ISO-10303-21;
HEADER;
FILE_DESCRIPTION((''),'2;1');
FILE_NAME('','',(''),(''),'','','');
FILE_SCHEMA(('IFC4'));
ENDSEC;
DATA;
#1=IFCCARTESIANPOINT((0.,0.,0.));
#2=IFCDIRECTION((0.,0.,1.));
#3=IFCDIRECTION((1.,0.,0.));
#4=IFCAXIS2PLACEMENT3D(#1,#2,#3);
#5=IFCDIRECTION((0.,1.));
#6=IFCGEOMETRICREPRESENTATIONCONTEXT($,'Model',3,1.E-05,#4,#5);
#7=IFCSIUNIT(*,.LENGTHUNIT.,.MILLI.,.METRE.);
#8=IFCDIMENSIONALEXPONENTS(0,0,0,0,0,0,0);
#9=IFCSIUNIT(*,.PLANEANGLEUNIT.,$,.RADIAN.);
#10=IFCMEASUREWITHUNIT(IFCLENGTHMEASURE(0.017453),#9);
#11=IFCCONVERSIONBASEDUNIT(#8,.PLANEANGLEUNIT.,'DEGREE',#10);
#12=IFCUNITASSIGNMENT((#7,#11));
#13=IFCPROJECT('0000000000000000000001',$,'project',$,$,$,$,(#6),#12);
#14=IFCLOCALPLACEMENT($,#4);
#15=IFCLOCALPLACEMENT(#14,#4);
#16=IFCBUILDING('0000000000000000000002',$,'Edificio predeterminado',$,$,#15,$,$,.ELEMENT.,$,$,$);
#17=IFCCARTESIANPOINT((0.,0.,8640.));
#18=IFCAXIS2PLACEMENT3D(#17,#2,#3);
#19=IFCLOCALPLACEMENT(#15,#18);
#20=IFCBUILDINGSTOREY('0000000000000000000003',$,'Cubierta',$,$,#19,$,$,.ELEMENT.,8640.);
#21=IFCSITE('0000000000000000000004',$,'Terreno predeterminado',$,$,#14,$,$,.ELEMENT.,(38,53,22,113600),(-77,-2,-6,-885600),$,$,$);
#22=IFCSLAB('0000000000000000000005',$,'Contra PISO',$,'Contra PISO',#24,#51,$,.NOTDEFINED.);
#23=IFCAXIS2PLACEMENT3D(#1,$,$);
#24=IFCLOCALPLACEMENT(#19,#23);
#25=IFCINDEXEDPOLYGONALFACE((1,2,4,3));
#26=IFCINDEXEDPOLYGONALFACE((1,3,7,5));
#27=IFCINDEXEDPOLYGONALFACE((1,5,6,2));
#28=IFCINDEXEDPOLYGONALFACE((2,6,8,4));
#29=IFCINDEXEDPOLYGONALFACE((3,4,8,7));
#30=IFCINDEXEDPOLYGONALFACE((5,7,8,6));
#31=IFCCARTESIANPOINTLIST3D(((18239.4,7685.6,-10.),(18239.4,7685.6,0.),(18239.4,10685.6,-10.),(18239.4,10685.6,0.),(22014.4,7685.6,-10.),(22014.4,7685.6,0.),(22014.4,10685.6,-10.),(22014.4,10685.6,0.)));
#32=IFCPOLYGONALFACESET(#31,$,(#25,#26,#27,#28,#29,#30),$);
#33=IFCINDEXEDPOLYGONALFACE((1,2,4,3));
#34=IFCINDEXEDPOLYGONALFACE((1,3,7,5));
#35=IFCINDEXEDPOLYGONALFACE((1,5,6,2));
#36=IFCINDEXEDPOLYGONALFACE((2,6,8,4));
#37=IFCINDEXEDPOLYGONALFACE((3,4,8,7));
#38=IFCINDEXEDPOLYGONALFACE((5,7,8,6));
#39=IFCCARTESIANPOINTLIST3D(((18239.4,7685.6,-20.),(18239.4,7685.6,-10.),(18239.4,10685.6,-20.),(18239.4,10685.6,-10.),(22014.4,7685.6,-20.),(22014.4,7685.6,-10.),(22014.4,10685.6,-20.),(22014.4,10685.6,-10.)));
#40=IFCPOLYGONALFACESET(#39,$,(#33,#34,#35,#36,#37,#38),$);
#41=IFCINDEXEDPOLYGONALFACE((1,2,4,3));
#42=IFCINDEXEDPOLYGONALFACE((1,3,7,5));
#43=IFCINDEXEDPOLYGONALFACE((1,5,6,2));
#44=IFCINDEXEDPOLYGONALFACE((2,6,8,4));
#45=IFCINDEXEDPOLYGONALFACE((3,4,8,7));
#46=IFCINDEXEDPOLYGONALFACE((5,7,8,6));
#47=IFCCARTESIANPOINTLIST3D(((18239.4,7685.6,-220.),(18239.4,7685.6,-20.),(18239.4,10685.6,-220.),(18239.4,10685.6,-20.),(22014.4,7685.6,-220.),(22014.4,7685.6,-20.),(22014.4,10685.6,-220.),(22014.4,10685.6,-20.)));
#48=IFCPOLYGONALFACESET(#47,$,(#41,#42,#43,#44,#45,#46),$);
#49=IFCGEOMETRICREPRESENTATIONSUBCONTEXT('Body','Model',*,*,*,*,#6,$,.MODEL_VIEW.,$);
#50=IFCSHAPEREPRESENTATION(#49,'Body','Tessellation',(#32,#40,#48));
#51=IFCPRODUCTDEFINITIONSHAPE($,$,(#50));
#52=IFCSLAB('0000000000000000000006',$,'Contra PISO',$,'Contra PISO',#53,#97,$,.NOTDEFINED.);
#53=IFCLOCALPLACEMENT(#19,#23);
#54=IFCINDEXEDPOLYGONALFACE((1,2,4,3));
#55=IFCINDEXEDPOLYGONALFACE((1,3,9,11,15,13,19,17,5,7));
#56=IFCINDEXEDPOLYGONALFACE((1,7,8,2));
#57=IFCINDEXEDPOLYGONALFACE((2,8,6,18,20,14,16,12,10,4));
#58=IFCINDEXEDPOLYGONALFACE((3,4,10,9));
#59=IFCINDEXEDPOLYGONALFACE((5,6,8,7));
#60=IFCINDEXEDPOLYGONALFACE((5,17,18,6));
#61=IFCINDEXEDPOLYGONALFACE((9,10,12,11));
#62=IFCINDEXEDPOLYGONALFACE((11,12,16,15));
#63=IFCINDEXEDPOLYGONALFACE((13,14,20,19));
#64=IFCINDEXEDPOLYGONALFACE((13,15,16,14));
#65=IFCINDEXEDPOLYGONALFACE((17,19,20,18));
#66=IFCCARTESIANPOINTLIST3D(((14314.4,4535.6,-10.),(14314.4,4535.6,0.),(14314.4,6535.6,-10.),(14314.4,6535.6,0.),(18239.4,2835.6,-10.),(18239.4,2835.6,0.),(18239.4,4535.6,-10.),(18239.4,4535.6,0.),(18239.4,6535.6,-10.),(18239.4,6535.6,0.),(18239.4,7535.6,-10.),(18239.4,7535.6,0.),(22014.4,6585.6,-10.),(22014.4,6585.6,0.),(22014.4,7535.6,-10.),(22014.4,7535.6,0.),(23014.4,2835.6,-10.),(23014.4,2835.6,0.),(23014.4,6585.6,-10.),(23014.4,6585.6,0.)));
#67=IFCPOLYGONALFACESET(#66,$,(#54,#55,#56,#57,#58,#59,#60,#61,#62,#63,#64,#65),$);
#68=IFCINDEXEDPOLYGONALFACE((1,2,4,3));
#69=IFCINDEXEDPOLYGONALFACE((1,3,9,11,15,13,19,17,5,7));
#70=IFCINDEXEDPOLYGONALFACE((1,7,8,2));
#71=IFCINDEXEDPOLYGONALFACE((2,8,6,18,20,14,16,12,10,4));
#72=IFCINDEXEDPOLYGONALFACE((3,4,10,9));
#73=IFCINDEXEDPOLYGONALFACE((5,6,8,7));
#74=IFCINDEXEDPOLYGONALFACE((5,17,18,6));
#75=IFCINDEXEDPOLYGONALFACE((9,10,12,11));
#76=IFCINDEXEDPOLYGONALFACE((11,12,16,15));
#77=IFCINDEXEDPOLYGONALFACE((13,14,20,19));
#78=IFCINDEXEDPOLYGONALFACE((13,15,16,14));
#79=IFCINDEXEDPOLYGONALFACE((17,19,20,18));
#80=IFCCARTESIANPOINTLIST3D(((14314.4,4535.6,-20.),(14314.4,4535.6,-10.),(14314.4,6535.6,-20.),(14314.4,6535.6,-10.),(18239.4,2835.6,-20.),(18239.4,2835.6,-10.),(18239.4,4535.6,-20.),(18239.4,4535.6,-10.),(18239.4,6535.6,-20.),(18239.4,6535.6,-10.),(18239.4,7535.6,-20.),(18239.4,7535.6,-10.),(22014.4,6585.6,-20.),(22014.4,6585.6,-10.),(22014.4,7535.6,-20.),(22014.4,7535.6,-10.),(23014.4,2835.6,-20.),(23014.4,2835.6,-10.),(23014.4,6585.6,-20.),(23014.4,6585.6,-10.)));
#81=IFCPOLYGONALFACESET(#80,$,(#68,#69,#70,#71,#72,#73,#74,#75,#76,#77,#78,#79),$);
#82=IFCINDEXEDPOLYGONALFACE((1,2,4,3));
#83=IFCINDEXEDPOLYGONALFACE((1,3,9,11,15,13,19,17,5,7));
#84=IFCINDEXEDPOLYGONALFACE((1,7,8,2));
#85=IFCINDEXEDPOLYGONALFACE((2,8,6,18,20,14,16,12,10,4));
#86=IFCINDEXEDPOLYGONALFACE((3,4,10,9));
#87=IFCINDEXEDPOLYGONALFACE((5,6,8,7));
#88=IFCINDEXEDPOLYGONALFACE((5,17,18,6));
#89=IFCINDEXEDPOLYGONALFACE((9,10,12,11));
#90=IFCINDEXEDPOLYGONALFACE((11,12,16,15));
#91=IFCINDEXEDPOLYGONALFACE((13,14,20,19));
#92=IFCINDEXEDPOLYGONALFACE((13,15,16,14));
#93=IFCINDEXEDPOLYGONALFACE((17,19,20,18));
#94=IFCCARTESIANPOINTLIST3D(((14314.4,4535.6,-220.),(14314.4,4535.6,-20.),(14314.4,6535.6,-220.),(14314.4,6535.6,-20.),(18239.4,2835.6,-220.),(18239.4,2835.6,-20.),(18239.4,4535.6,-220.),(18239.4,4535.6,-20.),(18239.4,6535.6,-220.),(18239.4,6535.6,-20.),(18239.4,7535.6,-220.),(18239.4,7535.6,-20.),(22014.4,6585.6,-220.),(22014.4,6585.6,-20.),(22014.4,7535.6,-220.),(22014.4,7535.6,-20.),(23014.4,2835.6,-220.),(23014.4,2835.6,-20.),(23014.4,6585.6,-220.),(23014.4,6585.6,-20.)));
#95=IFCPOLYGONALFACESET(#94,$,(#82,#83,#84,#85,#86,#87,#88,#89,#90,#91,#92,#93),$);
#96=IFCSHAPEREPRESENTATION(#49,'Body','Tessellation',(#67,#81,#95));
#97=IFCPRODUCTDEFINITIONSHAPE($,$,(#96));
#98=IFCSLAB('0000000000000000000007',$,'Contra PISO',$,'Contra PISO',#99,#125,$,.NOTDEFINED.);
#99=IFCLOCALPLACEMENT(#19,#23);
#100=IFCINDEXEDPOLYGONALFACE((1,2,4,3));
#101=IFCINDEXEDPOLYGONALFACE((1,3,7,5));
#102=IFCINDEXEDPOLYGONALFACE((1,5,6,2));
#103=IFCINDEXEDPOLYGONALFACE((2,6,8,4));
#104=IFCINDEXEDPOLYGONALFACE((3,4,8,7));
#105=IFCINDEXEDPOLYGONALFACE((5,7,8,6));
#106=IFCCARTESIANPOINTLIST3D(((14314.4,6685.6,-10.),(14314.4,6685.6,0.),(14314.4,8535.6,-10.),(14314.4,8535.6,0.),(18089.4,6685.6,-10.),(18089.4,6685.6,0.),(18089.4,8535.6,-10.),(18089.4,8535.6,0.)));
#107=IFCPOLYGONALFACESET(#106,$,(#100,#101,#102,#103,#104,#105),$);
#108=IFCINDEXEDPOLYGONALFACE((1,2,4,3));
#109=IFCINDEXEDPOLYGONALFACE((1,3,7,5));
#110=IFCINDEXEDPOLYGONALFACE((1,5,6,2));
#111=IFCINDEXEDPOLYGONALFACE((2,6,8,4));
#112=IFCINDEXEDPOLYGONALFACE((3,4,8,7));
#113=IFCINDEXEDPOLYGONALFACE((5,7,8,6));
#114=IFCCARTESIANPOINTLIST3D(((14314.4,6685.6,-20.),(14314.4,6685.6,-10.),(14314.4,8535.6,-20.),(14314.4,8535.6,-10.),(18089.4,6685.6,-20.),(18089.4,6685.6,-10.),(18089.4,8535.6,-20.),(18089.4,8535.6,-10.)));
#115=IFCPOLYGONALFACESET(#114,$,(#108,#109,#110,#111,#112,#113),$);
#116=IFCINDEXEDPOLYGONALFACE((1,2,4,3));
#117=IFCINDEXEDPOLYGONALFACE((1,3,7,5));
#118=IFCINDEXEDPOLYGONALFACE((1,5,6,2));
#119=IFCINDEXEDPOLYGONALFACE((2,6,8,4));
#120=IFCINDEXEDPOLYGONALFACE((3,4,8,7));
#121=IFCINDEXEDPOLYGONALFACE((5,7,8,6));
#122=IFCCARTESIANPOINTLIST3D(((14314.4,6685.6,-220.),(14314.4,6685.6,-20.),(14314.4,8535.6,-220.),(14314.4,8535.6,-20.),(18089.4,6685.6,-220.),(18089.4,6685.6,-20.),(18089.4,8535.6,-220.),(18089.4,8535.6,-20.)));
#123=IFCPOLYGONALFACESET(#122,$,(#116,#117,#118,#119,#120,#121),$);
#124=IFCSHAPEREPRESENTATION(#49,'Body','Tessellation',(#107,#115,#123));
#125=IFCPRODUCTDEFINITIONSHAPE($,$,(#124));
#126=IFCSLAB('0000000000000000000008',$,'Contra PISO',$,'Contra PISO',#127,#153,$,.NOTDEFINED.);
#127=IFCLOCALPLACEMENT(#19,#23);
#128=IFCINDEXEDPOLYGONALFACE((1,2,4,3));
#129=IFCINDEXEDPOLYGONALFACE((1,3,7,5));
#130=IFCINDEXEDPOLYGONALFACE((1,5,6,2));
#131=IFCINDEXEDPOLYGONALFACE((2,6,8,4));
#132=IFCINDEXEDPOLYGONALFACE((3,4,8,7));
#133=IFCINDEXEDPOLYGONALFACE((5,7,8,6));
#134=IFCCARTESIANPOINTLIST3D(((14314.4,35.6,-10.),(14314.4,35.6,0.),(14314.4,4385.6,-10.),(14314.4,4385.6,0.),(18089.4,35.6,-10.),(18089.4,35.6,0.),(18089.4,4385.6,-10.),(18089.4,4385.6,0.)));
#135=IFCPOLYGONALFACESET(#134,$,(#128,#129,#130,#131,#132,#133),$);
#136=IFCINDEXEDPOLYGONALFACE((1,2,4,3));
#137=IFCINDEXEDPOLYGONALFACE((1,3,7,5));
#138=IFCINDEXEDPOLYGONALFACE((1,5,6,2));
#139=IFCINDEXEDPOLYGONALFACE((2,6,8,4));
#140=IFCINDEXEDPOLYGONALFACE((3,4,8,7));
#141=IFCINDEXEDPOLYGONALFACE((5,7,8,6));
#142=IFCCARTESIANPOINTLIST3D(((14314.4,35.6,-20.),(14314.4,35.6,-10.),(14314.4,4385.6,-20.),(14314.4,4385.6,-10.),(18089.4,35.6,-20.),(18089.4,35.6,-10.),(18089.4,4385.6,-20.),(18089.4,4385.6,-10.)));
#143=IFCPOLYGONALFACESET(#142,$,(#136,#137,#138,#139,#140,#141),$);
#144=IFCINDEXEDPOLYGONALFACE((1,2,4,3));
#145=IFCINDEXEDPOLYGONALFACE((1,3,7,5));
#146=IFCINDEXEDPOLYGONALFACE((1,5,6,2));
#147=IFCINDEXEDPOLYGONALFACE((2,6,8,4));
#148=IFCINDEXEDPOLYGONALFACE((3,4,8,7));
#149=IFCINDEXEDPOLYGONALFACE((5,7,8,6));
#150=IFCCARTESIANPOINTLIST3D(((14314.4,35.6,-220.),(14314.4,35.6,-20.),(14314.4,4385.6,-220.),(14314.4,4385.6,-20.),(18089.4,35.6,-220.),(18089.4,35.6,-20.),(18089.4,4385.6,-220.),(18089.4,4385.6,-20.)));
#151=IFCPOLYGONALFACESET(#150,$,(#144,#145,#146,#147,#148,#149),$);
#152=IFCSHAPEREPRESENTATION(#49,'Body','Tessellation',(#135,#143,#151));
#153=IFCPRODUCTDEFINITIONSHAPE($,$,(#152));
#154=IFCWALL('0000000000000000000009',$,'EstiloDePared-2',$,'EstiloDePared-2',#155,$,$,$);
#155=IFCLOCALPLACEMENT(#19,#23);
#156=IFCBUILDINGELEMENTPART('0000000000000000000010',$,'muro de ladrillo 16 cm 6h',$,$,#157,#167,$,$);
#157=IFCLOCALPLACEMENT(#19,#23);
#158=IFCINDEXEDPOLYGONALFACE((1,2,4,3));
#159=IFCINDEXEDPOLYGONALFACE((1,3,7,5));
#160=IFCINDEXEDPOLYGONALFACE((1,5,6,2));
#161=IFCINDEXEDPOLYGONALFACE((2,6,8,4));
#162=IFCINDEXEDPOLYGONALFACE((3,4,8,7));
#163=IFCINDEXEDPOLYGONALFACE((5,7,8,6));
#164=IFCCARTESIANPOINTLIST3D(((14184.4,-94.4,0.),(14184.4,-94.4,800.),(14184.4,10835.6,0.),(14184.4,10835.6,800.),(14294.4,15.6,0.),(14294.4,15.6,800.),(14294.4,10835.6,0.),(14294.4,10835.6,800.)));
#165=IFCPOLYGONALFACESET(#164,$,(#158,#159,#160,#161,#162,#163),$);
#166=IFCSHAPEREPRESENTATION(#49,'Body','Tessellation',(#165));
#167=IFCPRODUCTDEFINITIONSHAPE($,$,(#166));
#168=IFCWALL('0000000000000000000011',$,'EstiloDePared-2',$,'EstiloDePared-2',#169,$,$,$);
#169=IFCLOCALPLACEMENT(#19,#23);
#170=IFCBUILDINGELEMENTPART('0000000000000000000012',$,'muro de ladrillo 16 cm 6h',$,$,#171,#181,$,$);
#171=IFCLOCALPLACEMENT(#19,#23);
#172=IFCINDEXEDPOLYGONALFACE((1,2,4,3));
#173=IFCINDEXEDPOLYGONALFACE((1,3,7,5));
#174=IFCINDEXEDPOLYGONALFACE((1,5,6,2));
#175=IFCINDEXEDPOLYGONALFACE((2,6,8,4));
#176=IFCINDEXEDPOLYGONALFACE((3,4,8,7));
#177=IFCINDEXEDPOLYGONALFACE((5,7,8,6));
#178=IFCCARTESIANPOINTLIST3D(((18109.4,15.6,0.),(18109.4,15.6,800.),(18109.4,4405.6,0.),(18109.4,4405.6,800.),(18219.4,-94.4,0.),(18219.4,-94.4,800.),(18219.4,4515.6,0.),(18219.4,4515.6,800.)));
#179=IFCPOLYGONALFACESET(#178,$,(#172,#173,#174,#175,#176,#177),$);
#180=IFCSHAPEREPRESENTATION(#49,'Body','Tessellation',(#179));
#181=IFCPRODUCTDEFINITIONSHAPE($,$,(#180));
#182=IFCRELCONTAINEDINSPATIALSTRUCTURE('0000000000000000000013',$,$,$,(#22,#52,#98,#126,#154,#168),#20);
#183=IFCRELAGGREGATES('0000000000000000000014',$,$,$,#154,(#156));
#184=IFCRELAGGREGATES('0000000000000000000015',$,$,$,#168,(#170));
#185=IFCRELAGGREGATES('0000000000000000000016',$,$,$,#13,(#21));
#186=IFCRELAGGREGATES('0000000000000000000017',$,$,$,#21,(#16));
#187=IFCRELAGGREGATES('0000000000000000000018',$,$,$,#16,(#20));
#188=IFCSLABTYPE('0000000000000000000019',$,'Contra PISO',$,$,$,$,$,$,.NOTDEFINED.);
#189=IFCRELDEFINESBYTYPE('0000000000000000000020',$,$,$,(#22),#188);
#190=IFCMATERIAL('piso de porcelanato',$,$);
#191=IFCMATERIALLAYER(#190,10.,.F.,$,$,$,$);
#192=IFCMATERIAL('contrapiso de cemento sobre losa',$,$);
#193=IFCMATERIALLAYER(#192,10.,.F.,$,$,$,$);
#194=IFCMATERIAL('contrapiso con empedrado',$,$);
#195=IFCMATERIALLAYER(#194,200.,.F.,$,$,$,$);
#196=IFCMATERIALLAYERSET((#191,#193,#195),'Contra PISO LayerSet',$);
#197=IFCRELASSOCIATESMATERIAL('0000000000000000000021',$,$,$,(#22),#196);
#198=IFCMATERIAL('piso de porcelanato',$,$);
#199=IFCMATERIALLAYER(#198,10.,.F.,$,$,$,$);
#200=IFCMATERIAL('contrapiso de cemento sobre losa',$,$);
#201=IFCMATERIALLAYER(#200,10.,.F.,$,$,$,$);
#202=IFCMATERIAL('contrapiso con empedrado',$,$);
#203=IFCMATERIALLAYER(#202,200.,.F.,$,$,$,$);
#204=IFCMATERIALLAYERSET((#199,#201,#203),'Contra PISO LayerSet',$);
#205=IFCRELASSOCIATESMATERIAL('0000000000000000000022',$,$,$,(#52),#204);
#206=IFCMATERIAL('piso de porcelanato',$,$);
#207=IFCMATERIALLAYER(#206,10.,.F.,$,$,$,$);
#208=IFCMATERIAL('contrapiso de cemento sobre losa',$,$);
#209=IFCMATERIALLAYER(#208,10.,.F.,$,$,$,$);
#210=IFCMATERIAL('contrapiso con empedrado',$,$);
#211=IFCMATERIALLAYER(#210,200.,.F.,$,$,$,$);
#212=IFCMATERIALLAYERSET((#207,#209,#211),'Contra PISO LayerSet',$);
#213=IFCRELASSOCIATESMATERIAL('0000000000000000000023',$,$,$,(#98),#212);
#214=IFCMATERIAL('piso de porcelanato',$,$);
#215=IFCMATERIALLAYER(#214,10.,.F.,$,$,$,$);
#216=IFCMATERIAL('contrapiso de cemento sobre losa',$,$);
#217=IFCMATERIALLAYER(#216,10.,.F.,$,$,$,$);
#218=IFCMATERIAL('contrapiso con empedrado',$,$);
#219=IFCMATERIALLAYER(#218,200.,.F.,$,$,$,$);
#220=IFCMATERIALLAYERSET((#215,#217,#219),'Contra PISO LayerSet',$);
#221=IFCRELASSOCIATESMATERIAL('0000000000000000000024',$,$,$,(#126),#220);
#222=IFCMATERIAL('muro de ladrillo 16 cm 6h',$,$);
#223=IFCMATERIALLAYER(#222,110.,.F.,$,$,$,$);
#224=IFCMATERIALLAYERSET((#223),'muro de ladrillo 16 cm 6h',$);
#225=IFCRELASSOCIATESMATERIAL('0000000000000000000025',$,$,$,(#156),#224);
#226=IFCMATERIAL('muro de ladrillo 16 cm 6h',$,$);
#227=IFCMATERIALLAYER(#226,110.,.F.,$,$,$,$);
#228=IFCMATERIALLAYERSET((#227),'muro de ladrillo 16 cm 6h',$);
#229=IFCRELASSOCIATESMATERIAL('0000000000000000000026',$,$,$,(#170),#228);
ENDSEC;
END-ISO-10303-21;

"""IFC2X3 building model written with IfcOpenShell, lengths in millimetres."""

from ifc_helpers import new_model, entity, si_unit, converted_unit, direction, frame, origin_with_axes, place, context, subcontext, project, spatial, polyline, outline, extrude, material, layer, layer_set, layer_usage, type_object, element, aggregate, save


model = new_model("IFC2X3")

# Units and contexts
model_context = context("Model", 3, precision=1e-05, world=origin_with_axes(), true_north=direction((0.0, 1.0)))
body_context = subcontext(model_context, "Body", "Model", "MODEL_VIEW")
ifc_project = project(units=[si_unit("LENGTHUNIT", "METRE", prefix="MILLI"), converted_unit("PLANEANGLEUNIT", "DEGREE", entity("IfcLengthMeasure", 0.017453), si_unit("PLANEANGLEUNIT", "RADIAN"), dimensions=[0, 0, 0, 0, 0, 0, 0])], contexts=[model_context])

# Site, building, storey
site_placement = place(None, origin_with_axes())
site = spatial("IfcSite", under=ifc_project, at=site_placement, Name="Terreno predeterminado", CompositionType="ELEMENT", RefLatitude=(38, 53, 22, 113600), RefLongitude=(-77, -2, -6, -885600))
building_placement = place(site_placement, origin_with_axes())
building = spatial("IfcBuilding", under=site, at=building_placement, Name="Edificio predeterminado", CompositionType="ELEMENT")
storey_placement = place(building_placement, frame((0.0, 0.0, 8640.0), z_axis=(0.0, 0.0, 1.0), x_axis=(1.0, 0.0, 0.0)))
storey = spatial("IfcBuildingStorey", under=building, at=storey_placement, Name="Cubierta", CompositionType="ELEMENT", Elevation=8640.0)

# Slabs
ifc_material_1 = material(Name="piso de porcelanato")
ifc_layer_1 = layer(ifc_material_1, 10.0, ventilated=False)
ifc_material_2 = material(Name="contrapiso de cemento sobre losa")
ifc_layer_2 = layer(ifc_material_2, 10.0, ventilated=False)
ifc_material_3 = material(Name="contrapiso con empedrado")
ifc_layer_3 = layer(ifc_material_3, 200.0, ventilated=False)
ifc_layer_set_1 = layer_set([ifc_layer_1, ifc_layer_2, ifc_layer_3], Name="Contra PISO LayerSet")
ifc_layer_usage_1 = layer_usage(ifc_layer_set_1, "AXIS3", "NEGATIVE", 0.0)
slab_type = type_object("IfcSlabType", Name="Contra PISO", PredefinedType="NOTDEFINED")
slab_1_placement = place(storey_placement, frame((0.0, 0.0, -8640.0), z_axis=(0.0, 0.0, 1.0), x_axis=(1.0, 0.0, 0.0)))
element("IfcSlab", 1, at=slab_1_placement, inside=storey, type_object=slab_type, material=ifc_layer_usage_1, Name="Contra PISO", ObjectType="Contra PISO", PredefinedType="NOTDEFINED", context=body_context, shape_type="SweptSolid", body=[
    extrude(outline(polyline([(0.0, 3000.0), (3775.0, 3000.0), (3775.0, 0.0), (0.0, 0.0), (0.0, 3000.0)])), frame((22014.4, 7685.6, 8630.0), z_axis=(0.0, 0.0, -1.0), x_axis=(-1.0, 0.0, 0.0)), (0.0, 0.0, -1.0), 10.0),
    extrude(outline(polyline([(0.0, 3000.0), (3775.0, 3000.0), (3775.0, 0.0), (0.0, 0.0), (0.0, 3000.0)])), frame((22014.4, 7685.6, 8620.0), z_axis=(0.0, 0.0, -1.0), x_axis=(-1.0, 0.0, 0.0)), (0.0, 0.0, -1.0), 10.0),
    extrude(outline(polyline([(0.0, 3000.0), (3775.0, 3000.0), (3775.0, 0.0), (0.0, 0.0), (0.0, 3000.0)])), frame((22014.4, 7685.6, 8420.0), z_axis=(0.0, 0.0, -1.0), x_axis=(-1.0, 0.0, 0.0)), (0.0, 0.0, -1.0), 200.0),
])
ifc_material_4 = material(Name="piso de porcelanato")
ifc_layer_4 = layer(ifc_material_4, 10.0, ventilated=False)
ifc_material_5 = material(Name="contrapiso de cemento sobre losa")
ifc_layer_5 = layer(ifc_material_5, 10.0, ventilated=False)
ifc_material_6 = material(Name="contrapiso con empedrado")
ifc_layer_6 = layer(ifc_material_6, 200.0, ventilated=False)
ifc_layer_set_2 = layer_set([ifc_layer_4, ifc_layer_5, ifc_layer_6], Name="Contra PISO LayerSet")
ifc_layer_usage_2 = layer_usage(ifc_layer_set_2, "AXIS3", "NEGATIVE", 0.0)
slab_2_placement = place(storey_placement, frame((0.0, 0.0, -8640.0), z_axis=(0.0, 0.0, 1.0), x_axis=(1.0, 0.0, 0.0)))
element("IfcSlab", 2, at=slab_2_placement, inside=storey, material=ifc_layer_usage_2, Name="Contra PISO", ObjectType="Contra PISO", PredefinedType="NOTDEFINED", context=body_context, shape_type="SweptSolid", body=[
    extrude(outline(polyline([(0.0, 1000.0), (-3925.0, 1000.0), (-3925.0, 3000.0), (0.0, 3000.0), (0.0, 4700.0), (4775.0, 4700.0), (4775.0, 950.0), (3775.0, 950.0), (3775.0, 0.0), (0.0, 0.0), (0.0, 1000.0)])), frame((18239.4, 7535.6, 8630.0), z_axis=(0.0, 0.0, -1.0), x_axis=(1.0, 0.0, 0.0)), (0.0, 0.0, -1.0), 10.0),
    extrude(outline(polyline([(0.0, 1000.0), (-3925.0, 1000.0), (-3925.0, 3000.0), (0.0, 3000.0), (0.0, 4700.0), (4775.0, 4700.0), (4775.0, 950.0), (3775.0, 950.0), (3775.0, 0.0), (0.0, 0.0), (0.0, 1000.0)])), frame((18239.4, 7535.6, 8620.0), z_axis=(0.0, 0.0, -1.0), x_axis=(1.0, 0.0, 0.0)), (0.0, 0.0, -1.0), 10.0),
    extrude(outline(polyline([(0.0, 1000.0), (-3925.0, 1000.0), (-3925.0, 3000.0), (0.0, 3000.0), (0.0, 4700.0), (4775.0, 4700.0), (4775.0, 950.0), (3775.0, 950.0), (3775.0, 0.0), (0.0, 0.0), (0.0, 1000.0)])), frame((18239.4, 7535.6, 8420.0), z_axis=(0.0, 0.0, -1.0), x_axis=(1.0, 0.0, 0.0)), (0.0, 0.0, -1.0), 200.0),
])
ifc_material_7 = material(Name="piso de porcelanato")
ifc_layer_7 = layer(ifc_material_7, 10.0, ventilated=False)
ifc_material_8 = material(Name="contrapiso de cemento sobre losa")
ifc_layer_8 = layer(ifc_material_8, 10.0, ventilated=False)
ifc_material_9 = material(Name="contrapiso con empedrado")
ifc_layer_9 = layer(ifc_material_9, 200.0, ventilated=False)
ifc_layer_set_3 = layer_set([ifc_layer_7, ifc_layer_8, ifc_layer_9], Name="Contra PISO LayerSet")
ifc_layer_usage_3 = layer_usage(ifc_layer_set_3, "AXIS3", "NEGATIVE", 0.0)
slab_3_placement = place(storey_placement, frame((0.0, 0.0, -8640.0), z_axis=(0.0, 0.0, 1.0), x_axis=(1.0, 0.0, 0.0)))
element("IfcSlab", 3, at=slab_3_placement, inside=storey, material=ifc_layer_usage_3, Name="Contra PISO", ObjectType="Contra PISO", PredefinedType="NOTDEFINED", context=body_context, shape_type="SweptSolid", body=[
    extrude(outline(polyline([(0.0, 1850.0), (3775.0, 1850.0), (3775.0, 0.0), (0.0, 0.0), (0.0, 1850.0)])), frame((18089.4, 6685.6, 8630.0), z_axis=(0.0, 0.0, -1.0), x_axis=(-1.0, 0.0, 0.0)), (0.0, 0.0, -1.0), 10.0),
    extrude(outline(polyline([(0.0, 1850.0), (3775.0, 1850.0), (3775.0, 0.0), (0.0, 0.0), (0.0, 1850.0)])), frame((18089.4, 6685.6, 8620.0), z_axis=(0.0, 0.0, -1.0), x_axis=(-1.0, 0.0, 0.0)), (0.0, 0.0, -1.0), 10.0),
    extrude(outline(polyline([(0.0, 1850.0), (3775.0, 1850.0), (3775.0, 0.0), (0.0, 0.0), (0.0, 1850.0)])), frame((18089.4, 6685.6, 8420.0), z_axis=(0.0, 0.0, -1.0), x_axis=(-1.0, 0.0, 0.0)), (0.0, 0.0, -1.0), 200.0),
])
ifc_material_10 = material(Name="piso de porcelanato")
ifc_layer_10 = layer(ifc_material_10, 10.0, ventilated=False)
ifc_material_11 = material(Name="contrapiso de cemento sobre losa")
ifc_layer_11 = layer(ifc_material_11, 10.0, ventilated=False)
ifc_material_12 = material(Name="contrapiso con empedrado")
ifc_layer_12 = layer(ifc_material_12, 200.0, ventilated=False)
ifc_layer_set_4 = layer_set([ifc_layer_10, ifc_layer_11, ifc_layer_12], Name="Contra PISO LayerSet")
ifc_layer_usage_4 = layer_usage(ifc_layer_set_4, "AXIS3", "NEGATIVE", 0.0)
slab_4_placement = place(storey_placement, frame((0.0, 0.0, -8640.0), z_axis=(0.0, 0.0, 1.0), x_axis=(1.0, 0.0, 0.0)))
element("IfcSlab", 4, at=slab_4_placement, inside=storey, material=ifc_layer_usage_4, Name="Contra PISO", ObjectType="Contra PISO", PredefinedType="NOTDEFINED", context=body_context, shape_type="SweptSolid", body=[
    extrude(outline(polyline([(0.0, 4350.0), (3775.0, 4350.0), (3775.0, 0.0), (0.0, 0.0), (0.0, 4350.0)])), frame((18089.4, 35.6, 8630.0), z_axis=(0.0, 0.0, -1.0), x_axis=(-1.0, 0.0, 0.0)), (0.0, 0.0, -1.0), 10.0),
    extrude(outline(polyline([(0.0, 4350.0), (3775.0, 4350.0), (3775.0, 0.0), (0.0, 0.0), (0.0, 4350.0)])), frame((18089.4, 35.6, 8620.0), z_axis=(0.0, 0.0, -1.0), x_axis=(-1.0, 0.0, 0.0)), (0.0, 0.0, -1.0), 10.0),
    extrude(outline(polyline([(0.0, 4350.0), (3775.0, 4350.0), (3775.0, 0.0), (0.0, 0.0), (0.0, 4350.0)])), frame((18089.4, 35.6, 8420.0), z_axis=(0.0, 0.0, -1.0), x_axis=(-1.0, 0.0, 0.0)), (0.0, 0.0, -1.0), 200.0),
])

# Walls, building element parts
wall_1_placement = place(storey_placement, frame((14239.4, -39.4, 0.0), z_axis=(0.0, 0.0, 1.0), x_axis=(0.0, 1.0, 0.0)))
wall_1 = element("IfcWall", 5, at=wall_1_placement, inside=storey, Name="EstiloDePared-2", ObjectType="EstiloDePared-2")
ifc_material_13 = material(Name="muro de ladrillo 16 cm 6h")
ifc_layer_13 = layer(ifc_material_13, 110.0, ventilated=False)
ifc_layer_set_5 = layer_set([ifc_layer_13], Name="muro de ladrillo 16 cm 6h")
ifc_layer_usage_5 = layer_usage(ifc_layer_set_5, "AXIS2", "NEGATIVE", -55.0)
building_element_part_1_placement = place(wall_1_placement, origin_with_axes())
building_element_part_1 = element("IfcBuildingElementPart", 6, at=building_element_part_1_placement, material=ifc_layer_usage_5, Name="muro de ladrillo 16 cm 6h", context=body_context, shape_type="SweptSolid", body=[
    extrude(outline(polyline([(10875.0, 55.0), (10875.0, -55.0), (55.0, -55.0), (-55.0, 55.0), (10875.0, 55.0)])), origin_with_axes(), (0.0, 0.0, 1.0), 800.0),
])
aggregate(wall_1, [building_element_part_1])
wall_2_placement = place(storey_placement, frame((18164.4, 4460.6, 0.0), z_axis=(0.0, 0.0, 1.0), x_axis=(0.0, -1.0, 0.0)))
wall_2 = element("IfcWall", 7, at=wall_2_placement, inside=storey, Name="EstiloDePared-2", ObjectType="EstiloDePared-2")
ifc_material_14 = material(Name="muro de ladrillo 16 cm 6h")
ifc_layer_14 = layer(ifc_material_14, 110.0, ventilated=False)
ifc_layer_set_6 = layer_set([ifc_layer_14], Name="muro de ladrillo 16 cm 6h")
ifc_layer_usage_6 = layer_usage(ifc_layer_set_6, "AXIS2", "NEGATIVE", -55.0)
building_element_part_2_placement = place(wall_2_placement, origin_with_axes())
building_element_part_2 = element("IfcBuildingElementPart", 8, at=building_element_part_2_placement, material=ifc_layer_usage_6, Name="muro de ladrillo 16 cm 6h", context=body_context, shape_type="SweptSolid", body=[
    extrude(outline(polyline([(4555.0, 55.0), (4445.0, -55.0), (55.0, -55.0), (-55.0, 55.0), (4555.0, 55.0)])), origin_with_axes(), (0.0, 0.0, 1.0), 800.0),
])
aggregate(wall_2, [building_element_part_2])

save(model, "model.ifc")
